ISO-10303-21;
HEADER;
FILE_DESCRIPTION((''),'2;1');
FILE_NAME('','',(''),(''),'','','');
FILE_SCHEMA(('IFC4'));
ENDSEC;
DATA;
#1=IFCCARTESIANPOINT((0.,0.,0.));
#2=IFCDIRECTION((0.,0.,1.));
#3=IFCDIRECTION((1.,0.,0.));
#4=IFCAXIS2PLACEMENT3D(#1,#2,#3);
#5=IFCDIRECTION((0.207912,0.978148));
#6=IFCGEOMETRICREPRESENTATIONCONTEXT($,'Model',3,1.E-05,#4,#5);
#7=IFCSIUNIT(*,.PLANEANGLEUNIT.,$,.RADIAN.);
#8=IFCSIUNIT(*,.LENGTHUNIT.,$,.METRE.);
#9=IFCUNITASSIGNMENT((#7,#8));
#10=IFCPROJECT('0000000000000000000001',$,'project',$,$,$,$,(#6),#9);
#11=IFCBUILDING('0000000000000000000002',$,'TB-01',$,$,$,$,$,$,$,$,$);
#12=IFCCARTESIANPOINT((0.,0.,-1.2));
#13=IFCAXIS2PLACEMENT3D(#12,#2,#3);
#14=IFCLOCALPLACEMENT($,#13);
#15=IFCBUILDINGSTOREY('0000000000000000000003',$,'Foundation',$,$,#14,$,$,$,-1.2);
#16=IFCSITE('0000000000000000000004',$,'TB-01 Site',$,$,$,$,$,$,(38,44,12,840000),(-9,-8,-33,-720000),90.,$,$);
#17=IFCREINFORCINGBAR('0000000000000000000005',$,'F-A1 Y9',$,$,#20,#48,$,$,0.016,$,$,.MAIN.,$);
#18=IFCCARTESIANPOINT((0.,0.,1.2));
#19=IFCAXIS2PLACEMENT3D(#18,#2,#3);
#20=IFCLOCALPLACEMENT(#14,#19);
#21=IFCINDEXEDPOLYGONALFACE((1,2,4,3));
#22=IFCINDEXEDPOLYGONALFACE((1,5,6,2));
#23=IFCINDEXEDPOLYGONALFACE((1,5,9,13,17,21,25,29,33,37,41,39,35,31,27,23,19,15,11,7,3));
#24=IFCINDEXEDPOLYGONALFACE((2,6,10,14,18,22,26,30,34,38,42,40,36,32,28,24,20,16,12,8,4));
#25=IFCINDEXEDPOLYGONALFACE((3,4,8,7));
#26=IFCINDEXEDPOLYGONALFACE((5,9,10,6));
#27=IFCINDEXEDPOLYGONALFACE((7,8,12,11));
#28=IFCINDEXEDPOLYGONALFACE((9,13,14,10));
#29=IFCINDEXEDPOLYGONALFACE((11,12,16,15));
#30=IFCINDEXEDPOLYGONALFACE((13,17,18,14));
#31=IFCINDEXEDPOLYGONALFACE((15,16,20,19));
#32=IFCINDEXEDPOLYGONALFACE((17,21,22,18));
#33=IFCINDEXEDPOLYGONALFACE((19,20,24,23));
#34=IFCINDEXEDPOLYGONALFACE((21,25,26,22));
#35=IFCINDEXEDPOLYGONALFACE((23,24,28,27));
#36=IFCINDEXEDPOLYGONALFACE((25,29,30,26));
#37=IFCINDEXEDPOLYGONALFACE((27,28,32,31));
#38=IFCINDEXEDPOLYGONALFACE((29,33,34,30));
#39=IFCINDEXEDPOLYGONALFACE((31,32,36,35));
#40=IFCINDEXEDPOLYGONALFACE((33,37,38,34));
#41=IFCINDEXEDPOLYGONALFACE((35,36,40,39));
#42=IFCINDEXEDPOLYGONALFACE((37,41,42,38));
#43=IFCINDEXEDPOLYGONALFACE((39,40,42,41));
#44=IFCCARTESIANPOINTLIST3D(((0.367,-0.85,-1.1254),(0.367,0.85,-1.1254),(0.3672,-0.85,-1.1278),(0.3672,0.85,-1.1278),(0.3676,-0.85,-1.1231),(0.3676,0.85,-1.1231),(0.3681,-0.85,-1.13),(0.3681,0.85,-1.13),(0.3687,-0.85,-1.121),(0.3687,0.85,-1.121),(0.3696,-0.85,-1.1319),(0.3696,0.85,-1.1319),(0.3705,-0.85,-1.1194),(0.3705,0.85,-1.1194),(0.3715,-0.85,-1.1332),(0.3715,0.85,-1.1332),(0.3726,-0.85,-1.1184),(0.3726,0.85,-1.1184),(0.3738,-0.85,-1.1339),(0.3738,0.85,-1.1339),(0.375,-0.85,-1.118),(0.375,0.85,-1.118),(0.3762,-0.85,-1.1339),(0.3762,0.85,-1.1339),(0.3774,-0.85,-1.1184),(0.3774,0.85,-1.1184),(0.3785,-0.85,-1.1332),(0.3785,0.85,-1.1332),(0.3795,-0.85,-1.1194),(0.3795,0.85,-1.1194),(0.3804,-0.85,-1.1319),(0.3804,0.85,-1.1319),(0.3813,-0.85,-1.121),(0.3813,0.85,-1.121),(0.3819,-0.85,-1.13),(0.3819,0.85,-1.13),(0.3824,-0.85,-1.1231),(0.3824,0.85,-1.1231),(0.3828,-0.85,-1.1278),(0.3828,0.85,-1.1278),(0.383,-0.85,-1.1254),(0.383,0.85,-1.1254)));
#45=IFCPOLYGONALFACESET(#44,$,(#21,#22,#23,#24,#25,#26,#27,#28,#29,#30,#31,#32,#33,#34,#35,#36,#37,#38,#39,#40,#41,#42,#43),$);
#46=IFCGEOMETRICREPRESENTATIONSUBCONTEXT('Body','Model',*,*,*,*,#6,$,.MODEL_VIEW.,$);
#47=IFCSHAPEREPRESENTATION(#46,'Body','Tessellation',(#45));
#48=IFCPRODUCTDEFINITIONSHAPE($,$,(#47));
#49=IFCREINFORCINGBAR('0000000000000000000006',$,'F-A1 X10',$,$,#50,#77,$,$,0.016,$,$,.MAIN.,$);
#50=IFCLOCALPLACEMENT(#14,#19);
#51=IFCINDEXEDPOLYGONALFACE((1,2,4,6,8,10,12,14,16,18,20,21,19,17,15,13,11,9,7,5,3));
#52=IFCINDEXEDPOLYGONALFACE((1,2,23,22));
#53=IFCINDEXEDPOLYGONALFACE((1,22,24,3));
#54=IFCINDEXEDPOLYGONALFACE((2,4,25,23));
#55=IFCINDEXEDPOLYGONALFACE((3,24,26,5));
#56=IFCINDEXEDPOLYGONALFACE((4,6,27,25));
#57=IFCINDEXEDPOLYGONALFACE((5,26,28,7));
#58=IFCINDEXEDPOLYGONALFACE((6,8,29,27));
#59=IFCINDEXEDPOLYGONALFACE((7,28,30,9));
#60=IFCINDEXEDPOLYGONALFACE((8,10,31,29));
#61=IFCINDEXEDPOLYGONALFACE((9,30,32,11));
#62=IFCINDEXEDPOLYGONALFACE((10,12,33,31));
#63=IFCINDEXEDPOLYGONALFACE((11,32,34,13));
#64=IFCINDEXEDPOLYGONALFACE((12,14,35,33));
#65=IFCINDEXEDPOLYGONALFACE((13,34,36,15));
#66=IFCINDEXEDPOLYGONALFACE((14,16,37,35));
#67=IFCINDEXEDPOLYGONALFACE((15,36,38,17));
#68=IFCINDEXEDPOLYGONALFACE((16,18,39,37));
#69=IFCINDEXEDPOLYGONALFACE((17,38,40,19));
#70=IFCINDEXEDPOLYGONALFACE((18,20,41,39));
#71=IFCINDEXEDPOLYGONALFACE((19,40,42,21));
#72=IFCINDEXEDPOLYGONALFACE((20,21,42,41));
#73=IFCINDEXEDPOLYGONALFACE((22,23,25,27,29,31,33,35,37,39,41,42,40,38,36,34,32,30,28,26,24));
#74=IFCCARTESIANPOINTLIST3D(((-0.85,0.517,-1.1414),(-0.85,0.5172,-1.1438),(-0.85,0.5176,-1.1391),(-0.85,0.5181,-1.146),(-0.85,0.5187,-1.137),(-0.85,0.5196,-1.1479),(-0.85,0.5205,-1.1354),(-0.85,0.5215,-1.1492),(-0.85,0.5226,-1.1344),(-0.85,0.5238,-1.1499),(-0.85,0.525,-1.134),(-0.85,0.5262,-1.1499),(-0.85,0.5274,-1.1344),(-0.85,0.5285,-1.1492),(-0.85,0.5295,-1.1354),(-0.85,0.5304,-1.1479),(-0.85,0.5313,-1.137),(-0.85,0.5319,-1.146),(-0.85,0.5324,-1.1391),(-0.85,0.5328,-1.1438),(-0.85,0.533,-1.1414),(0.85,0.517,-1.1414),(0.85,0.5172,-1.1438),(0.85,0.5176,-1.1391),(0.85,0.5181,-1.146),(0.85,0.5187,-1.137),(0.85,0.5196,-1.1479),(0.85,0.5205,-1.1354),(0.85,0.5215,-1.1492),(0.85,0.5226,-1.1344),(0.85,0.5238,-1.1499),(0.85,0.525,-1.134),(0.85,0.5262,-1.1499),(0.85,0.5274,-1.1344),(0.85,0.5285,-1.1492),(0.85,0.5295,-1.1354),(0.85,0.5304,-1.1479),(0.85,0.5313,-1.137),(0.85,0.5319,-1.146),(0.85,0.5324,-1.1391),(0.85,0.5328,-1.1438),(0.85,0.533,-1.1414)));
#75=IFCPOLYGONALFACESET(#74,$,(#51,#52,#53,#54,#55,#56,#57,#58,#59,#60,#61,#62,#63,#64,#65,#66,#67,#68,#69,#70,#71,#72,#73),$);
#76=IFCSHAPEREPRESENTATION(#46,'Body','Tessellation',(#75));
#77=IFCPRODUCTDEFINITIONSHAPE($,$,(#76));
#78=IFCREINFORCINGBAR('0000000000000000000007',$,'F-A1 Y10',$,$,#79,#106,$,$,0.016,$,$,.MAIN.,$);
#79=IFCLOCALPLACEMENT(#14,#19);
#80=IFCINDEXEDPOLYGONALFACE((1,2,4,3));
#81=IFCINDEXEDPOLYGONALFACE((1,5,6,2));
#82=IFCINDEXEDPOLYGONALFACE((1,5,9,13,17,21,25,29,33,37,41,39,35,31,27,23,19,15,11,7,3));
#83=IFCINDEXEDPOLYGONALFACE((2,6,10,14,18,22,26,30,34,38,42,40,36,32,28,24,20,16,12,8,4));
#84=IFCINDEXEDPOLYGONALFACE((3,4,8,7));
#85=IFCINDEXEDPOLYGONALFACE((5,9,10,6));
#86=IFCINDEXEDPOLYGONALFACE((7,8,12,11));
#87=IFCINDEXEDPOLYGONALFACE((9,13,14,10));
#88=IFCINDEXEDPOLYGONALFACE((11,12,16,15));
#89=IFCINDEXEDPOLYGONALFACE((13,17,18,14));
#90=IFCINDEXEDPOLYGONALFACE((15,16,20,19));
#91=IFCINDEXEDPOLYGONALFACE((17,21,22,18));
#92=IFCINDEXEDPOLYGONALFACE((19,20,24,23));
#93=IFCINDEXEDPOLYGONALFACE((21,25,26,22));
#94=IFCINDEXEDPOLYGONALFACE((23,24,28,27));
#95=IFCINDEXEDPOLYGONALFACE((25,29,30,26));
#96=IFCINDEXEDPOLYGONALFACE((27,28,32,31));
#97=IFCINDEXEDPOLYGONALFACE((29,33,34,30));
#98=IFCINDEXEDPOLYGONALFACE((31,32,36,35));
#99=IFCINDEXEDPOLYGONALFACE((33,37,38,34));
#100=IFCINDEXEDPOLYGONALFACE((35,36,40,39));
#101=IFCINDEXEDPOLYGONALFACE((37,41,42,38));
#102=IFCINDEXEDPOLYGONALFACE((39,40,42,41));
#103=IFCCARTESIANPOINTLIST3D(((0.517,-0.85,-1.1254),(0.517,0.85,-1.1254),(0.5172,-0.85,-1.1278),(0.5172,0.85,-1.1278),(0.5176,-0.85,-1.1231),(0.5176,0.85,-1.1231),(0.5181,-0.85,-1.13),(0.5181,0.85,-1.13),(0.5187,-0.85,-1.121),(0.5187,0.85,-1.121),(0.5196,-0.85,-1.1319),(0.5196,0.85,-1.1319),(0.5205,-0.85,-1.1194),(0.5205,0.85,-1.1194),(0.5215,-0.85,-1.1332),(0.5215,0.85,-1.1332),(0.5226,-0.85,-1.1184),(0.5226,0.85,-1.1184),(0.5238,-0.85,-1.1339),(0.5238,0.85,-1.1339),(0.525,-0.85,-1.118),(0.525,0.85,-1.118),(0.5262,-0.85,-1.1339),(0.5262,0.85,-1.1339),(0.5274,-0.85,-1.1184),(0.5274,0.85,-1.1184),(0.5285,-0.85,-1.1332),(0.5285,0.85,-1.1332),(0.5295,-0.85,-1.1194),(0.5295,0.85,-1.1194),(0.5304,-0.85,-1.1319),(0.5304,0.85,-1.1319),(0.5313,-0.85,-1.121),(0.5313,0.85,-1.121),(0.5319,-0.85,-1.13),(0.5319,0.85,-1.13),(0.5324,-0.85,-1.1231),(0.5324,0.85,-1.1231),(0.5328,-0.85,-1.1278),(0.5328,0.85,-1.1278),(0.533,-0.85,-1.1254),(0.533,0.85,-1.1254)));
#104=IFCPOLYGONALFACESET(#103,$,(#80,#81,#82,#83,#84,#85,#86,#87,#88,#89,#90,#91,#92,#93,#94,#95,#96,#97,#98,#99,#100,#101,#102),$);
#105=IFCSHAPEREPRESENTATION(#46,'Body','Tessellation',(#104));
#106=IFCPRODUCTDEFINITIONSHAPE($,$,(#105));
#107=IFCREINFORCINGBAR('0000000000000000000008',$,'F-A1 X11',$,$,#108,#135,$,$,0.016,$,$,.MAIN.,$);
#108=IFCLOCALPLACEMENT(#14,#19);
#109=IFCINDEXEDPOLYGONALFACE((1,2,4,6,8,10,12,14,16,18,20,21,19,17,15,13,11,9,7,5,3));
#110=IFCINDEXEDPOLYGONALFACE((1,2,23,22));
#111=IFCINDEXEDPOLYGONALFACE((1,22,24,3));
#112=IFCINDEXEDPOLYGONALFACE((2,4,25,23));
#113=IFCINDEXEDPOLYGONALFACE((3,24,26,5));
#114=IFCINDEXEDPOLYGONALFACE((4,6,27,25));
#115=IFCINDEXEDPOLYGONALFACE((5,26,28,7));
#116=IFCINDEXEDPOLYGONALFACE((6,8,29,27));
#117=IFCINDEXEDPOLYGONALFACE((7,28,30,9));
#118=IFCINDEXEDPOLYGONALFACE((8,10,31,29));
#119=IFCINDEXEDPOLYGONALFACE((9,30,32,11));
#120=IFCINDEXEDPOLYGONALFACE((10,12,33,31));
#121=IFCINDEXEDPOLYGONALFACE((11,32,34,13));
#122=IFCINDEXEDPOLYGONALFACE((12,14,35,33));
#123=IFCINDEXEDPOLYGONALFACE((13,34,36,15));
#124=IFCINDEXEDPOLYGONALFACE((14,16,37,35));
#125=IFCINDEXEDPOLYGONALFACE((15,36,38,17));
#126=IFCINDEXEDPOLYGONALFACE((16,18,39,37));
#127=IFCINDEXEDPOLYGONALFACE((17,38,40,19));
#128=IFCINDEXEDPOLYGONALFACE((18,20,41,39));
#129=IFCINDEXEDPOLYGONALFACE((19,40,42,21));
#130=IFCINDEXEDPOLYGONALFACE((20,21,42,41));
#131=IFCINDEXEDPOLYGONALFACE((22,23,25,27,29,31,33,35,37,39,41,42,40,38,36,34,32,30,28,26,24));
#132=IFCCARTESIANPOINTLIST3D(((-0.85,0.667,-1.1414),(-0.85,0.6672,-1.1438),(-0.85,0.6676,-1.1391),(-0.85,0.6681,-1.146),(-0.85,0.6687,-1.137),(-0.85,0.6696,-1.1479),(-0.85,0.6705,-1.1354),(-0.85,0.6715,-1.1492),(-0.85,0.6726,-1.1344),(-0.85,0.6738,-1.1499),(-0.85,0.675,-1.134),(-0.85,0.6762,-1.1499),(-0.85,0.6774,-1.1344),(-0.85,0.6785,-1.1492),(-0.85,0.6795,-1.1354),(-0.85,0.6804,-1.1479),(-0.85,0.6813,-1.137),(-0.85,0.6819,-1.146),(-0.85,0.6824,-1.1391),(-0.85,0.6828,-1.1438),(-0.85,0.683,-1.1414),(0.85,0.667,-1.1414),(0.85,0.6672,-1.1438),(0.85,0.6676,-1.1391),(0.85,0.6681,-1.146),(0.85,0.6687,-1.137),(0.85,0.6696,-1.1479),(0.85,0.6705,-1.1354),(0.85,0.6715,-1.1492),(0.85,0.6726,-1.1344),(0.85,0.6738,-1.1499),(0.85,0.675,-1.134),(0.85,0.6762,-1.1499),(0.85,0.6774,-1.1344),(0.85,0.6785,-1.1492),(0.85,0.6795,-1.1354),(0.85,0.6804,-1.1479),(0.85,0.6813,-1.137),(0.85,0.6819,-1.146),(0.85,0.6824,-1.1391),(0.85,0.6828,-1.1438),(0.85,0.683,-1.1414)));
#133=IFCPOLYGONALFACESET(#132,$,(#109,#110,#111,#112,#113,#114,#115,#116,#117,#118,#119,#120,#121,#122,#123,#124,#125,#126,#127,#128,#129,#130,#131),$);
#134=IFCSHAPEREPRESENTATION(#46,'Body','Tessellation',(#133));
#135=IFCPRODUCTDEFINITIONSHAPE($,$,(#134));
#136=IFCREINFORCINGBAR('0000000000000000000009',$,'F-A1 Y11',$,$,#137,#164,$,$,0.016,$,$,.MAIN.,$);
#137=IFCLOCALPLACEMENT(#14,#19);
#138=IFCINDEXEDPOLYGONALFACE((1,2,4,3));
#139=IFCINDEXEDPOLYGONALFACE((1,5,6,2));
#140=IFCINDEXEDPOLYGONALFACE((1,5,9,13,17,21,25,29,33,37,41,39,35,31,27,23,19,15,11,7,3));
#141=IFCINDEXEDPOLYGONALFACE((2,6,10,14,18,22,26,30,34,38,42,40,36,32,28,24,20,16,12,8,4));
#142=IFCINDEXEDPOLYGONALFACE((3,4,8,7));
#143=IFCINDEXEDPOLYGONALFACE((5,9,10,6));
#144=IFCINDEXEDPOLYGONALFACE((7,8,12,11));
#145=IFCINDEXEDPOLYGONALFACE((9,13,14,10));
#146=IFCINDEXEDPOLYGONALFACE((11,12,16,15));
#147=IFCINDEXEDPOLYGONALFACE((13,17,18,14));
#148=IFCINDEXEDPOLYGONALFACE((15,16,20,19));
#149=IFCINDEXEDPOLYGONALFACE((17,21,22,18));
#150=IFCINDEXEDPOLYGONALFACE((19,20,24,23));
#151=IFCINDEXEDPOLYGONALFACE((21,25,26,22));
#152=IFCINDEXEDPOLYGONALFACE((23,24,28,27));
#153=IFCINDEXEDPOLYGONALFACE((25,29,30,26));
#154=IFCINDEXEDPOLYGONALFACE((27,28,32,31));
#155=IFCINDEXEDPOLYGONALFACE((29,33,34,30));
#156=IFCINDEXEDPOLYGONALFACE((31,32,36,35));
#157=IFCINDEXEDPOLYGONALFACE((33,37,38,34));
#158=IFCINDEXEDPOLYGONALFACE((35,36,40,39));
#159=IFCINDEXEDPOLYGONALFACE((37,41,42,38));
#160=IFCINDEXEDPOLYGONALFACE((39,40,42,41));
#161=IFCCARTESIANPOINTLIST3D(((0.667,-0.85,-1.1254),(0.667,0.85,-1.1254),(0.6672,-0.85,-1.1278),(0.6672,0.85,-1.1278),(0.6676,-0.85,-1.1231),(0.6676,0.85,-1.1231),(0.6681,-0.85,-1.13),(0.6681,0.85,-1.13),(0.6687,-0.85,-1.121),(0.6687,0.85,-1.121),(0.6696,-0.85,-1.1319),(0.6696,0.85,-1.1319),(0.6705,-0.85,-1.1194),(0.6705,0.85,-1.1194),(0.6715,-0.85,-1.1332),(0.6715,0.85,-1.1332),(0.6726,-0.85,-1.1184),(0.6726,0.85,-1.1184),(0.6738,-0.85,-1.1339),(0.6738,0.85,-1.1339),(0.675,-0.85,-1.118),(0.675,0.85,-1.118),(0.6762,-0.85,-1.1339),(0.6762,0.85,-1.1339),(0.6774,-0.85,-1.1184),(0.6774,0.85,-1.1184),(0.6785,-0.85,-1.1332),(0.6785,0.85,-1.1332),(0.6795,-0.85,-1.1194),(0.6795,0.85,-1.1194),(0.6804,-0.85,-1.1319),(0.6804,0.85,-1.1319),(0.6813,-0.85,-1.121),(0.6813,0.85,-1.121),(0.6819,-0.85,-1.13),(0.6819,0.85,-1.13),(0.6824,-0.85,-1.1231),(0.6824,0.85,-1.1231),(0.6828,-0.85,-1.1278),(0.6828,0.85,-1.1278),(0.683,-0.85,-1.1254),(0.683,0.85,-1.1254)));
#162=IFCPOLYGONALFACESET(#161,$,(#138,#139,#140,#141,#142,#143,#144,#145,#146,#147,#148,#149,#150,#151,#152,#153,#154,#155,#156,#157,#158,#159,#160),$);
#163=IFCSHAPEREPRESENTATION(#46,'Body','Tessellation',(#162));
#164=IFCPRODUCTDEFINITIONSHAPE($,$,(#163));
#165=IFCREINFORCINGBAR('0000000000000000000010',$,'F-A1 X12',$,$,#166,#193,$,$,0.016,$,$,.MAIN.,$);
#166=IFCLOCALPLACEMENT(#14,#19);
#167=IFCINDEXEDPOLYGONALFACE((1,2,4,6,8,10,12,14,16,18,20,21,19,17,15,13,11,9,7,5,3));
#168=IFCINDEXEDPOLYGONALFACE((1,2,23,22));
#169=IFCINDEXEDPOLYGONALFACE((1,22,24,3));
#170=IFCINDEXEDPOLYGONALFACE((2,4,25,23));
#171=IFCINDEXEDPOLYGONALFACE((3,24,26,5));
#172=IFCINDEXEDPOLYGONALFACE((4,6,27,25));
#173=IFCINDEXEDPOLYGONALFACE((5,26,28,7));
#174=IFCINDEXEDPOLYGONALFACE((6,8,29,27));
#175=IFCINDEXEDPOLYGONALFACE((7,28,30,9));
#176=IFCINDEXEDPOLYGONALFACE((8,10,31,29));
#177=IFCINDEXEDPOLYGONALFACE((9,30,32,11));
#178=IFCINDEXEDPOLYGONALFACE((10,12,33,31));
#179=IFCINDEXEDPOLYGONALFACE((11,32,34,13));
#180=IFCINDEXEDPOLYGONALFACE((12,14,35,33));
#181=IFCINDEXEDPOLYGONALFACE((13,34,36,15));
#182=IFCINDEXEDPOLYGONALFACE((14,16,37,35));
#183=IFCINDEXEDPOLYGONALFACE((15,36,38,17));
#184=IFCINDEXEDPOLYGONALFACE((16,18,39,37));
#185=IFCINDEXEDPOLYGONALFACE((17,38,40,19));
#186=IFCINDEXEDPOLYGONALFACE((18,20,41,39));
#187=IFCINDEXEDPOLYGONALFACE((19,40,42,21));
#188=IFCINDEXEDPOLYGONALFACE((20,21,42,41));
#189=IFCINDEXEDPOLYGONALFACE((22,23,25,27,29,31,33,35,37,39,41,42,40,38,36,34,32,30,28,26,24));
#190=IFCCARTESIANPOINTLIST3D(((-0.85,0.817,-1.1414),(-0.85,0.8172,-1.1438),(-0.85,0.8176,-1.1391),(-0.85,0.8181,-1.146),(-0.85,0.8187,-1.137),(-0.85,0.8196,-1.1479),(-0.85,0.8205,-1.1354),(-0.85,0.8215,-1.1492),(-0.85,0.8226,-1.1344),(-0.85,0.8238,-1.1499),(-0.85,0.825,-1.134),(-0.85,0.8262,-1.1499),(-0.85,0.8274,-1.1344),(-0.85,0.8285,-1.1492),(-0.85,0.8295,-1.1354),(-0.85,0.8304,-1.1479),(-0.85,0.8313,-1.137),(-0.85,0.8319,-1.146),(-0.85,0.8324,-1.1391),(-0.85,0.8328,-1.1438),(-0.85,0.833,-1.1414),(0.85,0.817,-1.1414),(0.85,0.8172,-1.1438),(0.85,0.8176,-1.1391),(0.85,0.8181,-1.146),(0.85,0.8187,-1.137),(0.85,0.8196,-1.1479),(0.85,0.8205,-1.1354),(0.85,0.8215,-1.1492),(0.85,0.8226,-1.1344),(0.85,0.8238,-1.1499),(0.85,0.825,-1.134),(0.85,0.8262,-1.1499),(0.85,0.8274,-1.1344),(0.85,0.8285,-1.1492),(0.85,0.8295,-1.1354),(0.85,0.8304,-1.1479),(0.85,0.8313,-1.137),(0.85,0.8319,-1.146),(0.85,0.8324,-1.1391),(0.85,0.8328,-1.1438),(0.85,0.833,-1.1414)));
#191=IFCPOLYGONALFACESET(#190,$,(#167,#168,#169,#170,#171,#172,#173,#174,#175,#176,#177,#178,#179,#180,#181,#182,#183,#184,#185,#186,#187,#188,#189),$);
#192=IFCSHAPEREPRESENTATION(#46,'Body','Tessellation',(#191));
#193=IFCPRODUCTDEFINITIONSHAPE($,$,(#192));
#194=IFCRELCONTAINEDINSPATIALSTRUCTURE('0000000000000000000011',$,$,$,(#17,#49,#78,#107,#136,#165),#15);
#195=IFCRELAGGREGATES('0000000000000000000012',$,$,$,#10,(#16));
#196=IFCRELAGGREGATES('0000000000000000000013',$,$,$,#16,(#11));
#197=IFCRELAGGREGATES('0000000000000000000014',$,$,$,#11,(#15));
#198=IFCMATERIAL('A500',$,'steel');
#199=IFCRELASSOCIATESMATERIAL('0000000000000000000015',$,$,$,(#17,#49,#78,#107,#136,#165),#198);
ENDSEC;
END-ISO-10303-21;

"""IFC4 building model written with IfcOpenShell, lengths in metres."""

from ifc_helpers import new_model, entity, si_unit, direction, frame, origin_with_axes, place, context, subcontext, project, spatial, material, element, save


model = new_model("IFC4")

# Units and contexts
model_context = context("Model", 3, precision=1e-05, world=origin_with_axes(), true_north=direction((0.207912, 0.978148)))
body_context = subcontext(model_context, "Body", "Model", "MODEL_VIEW")
ifc_project = project(units=[si_unit("PLANEANGLEUNIT", "RADIAN"), si_unit("LENGTHUNIT", "METRE")], contexts=[model_context])

# Site, building, storey
site = spatial("IfcSite", under=ifc_project, Name="TB-01 Site", RefLatitude=(38, 44, 12, 840000), RefLongitude=(-9, -8, -33, -720000), RefElevation=90.0)
building = spatial("IfcBuilding", under=site, Name="TB-01")
storey_placement = place(None, frame((0.0, 0.0, -1.2), z_axis=(0.0, 0.0, 1.0), x_axis=(1.0, 0.0, 0.0)))
storey = spatial("IfcBuildingStorey", under=building, at=storey_placement, Name="Foundation", Elevation=-1.2)

# Reinforcing bars
ifc_material_1 = material(Name="A500", Category="steel")
reinforcing_bar_1_placement = place(storey_placement, frame((0.0, 0.0, 1.2), z_axis=(0.0, 0.0, 1.0), x_axis=(1.0, 0.0, 0.0)))
element("IfcReinforcingBar", 1, at=reinforcing_bar_1_placement, inside=storey, material=ifc_material_1, Name="F-A1 Y9", NominalDiameter=0.016, PredefinedType="MAIN", context=body_context, shape_type="AdvancedSweptSolid", body=[
    entity("IfcSweptDiskSolid", entity("IfcPolyline", [entity("IfcCartesianPoint", [0.375, -0.85, -1.126]), entity("IfcCartesianPoint", [0.375, 0.85, -1.126])]), 0.008),
])
reinforcing_bar_2_placement = place(storey_placement, frame((0.0, 0.0, 1.2), z_axis=(0.0, 0.0, 1.0), x_axis=(1.0, 0.0, 0.0)))
element("IfcReinforcingBar", 2, at=reinforcing_bar_2_placement, inside=storey, material=ifc_material_1, Name="F-A1 X10", NominalDiameter=0.016, PredefinedType="MAIN", context=body_context, shape_type="AdvancedSweptSolid", body=[
    entity("IfcSweptDiskSolid", entity("IfcPolyline", [entity("IfcCartesianPoint", [-0.85, 0.525, -1.142]), entity("IfcCartesianPoint", [0.85, 0.525, -1.142])]), 0.008),
])
reinforcing_bar_3_placement = place(storey_placement, frame((0.0, 0.0, 1.2), z_axis=(0.0, 0.0, 1.0), x_axis=(1.0, 0.0, 0.0)))
element("IfcReinforcingBar", 3, at=reinforcing_bar_3_placement, inside=storey, material=ifc_material_1, Name="F-A1 Y10", NominalDiameter=0.016, PredefinedType="MAIN", context=body_context, shape_type="AdvancedSweptSolid", body=[
    entity("IfcSweptDiskSolid", entity("IfcPolyline", [entity("IfcCartesianPoint", [0.525, -0.85, -1.126]), entity("IfcCartesianPoint", [0.525, 0.85, -1.126])]), 0.008),
])
reinforcing_bar_4_placement = place(storey_placement, frame((0.0, 0.0, 1.2), z_axis=(0.0, 0.0, 1.0), x_axis=(1.0, 0.0, 0.0)))
element("IfcReinforcingBar", 4, at=reinforcing_bar_4_placement, inside=storey, material=ifc_material_1, Name="F-A1 X11", NominalDiameter=0.016, PredefinedType="MAIN", context=body_context, shape_type="AdvancedSweptSolid", body=[
    entity("IfcSweptDiskSolid", entity("IfcPolyline", [entity("IfcCartesianPoint", [-0.85, 0.675, -1.142]), entity("IfcCartesianPoint", [0.85, 0.675, -1.142])]), 0.008),
])
reinforcing_bar_5_placement = place(storey_placement, frame((0.0, 0.0, 1.2), z_axis=(0.0, 0.0, 1.0), x_axis=(1.0, 0.0, 0.0)))
element("IfcReinforcingBar", 5, at=reinforcing_bar_5_placement, inside=storey, material=ifc_material_1, Name="F-A1 Y11", NominalDiameter=0.016, PredefinedType="MAIN", context=body_context, shape_type="AdvancedSweptSolid", body=[
    entity("IfcSweptDiskSolid", entity("IfcPolyline", [entity("IfcCartesianPoint", [0.675, -0.85, -1.126]), entity("IfcCartesianPoint", [0.675, 0.85, -1.126])]), 0.008),
])
reinforcing_bar_6_placement = place(storey_placement, frame((0.0, 0.0, 1.2), z_axis=(0.0, 0.0, 1.0), x_axis=(1.0, 0.0, 0.0)))
element("IfcReinforcingBar", 6, at=reinforcing_bar_6_placement, inside=storey, material=ifc_material_1, Name="F-A1 X12", NominalDiameter=0.016, PredefinedType="MAIN", context=body_context, shape_type="AdvancedSweptSolid", body=[
    entity("IfcSweptDiskSolid", entity("IfcPolyline", [entity("IfcCartesianPoint", [-0.85, 0.825, -1.142]), entity("IfcCartesianPoint", [0.85, 0.825, -1.142])]), 0.008),
])

save(model, "model.ifc")
